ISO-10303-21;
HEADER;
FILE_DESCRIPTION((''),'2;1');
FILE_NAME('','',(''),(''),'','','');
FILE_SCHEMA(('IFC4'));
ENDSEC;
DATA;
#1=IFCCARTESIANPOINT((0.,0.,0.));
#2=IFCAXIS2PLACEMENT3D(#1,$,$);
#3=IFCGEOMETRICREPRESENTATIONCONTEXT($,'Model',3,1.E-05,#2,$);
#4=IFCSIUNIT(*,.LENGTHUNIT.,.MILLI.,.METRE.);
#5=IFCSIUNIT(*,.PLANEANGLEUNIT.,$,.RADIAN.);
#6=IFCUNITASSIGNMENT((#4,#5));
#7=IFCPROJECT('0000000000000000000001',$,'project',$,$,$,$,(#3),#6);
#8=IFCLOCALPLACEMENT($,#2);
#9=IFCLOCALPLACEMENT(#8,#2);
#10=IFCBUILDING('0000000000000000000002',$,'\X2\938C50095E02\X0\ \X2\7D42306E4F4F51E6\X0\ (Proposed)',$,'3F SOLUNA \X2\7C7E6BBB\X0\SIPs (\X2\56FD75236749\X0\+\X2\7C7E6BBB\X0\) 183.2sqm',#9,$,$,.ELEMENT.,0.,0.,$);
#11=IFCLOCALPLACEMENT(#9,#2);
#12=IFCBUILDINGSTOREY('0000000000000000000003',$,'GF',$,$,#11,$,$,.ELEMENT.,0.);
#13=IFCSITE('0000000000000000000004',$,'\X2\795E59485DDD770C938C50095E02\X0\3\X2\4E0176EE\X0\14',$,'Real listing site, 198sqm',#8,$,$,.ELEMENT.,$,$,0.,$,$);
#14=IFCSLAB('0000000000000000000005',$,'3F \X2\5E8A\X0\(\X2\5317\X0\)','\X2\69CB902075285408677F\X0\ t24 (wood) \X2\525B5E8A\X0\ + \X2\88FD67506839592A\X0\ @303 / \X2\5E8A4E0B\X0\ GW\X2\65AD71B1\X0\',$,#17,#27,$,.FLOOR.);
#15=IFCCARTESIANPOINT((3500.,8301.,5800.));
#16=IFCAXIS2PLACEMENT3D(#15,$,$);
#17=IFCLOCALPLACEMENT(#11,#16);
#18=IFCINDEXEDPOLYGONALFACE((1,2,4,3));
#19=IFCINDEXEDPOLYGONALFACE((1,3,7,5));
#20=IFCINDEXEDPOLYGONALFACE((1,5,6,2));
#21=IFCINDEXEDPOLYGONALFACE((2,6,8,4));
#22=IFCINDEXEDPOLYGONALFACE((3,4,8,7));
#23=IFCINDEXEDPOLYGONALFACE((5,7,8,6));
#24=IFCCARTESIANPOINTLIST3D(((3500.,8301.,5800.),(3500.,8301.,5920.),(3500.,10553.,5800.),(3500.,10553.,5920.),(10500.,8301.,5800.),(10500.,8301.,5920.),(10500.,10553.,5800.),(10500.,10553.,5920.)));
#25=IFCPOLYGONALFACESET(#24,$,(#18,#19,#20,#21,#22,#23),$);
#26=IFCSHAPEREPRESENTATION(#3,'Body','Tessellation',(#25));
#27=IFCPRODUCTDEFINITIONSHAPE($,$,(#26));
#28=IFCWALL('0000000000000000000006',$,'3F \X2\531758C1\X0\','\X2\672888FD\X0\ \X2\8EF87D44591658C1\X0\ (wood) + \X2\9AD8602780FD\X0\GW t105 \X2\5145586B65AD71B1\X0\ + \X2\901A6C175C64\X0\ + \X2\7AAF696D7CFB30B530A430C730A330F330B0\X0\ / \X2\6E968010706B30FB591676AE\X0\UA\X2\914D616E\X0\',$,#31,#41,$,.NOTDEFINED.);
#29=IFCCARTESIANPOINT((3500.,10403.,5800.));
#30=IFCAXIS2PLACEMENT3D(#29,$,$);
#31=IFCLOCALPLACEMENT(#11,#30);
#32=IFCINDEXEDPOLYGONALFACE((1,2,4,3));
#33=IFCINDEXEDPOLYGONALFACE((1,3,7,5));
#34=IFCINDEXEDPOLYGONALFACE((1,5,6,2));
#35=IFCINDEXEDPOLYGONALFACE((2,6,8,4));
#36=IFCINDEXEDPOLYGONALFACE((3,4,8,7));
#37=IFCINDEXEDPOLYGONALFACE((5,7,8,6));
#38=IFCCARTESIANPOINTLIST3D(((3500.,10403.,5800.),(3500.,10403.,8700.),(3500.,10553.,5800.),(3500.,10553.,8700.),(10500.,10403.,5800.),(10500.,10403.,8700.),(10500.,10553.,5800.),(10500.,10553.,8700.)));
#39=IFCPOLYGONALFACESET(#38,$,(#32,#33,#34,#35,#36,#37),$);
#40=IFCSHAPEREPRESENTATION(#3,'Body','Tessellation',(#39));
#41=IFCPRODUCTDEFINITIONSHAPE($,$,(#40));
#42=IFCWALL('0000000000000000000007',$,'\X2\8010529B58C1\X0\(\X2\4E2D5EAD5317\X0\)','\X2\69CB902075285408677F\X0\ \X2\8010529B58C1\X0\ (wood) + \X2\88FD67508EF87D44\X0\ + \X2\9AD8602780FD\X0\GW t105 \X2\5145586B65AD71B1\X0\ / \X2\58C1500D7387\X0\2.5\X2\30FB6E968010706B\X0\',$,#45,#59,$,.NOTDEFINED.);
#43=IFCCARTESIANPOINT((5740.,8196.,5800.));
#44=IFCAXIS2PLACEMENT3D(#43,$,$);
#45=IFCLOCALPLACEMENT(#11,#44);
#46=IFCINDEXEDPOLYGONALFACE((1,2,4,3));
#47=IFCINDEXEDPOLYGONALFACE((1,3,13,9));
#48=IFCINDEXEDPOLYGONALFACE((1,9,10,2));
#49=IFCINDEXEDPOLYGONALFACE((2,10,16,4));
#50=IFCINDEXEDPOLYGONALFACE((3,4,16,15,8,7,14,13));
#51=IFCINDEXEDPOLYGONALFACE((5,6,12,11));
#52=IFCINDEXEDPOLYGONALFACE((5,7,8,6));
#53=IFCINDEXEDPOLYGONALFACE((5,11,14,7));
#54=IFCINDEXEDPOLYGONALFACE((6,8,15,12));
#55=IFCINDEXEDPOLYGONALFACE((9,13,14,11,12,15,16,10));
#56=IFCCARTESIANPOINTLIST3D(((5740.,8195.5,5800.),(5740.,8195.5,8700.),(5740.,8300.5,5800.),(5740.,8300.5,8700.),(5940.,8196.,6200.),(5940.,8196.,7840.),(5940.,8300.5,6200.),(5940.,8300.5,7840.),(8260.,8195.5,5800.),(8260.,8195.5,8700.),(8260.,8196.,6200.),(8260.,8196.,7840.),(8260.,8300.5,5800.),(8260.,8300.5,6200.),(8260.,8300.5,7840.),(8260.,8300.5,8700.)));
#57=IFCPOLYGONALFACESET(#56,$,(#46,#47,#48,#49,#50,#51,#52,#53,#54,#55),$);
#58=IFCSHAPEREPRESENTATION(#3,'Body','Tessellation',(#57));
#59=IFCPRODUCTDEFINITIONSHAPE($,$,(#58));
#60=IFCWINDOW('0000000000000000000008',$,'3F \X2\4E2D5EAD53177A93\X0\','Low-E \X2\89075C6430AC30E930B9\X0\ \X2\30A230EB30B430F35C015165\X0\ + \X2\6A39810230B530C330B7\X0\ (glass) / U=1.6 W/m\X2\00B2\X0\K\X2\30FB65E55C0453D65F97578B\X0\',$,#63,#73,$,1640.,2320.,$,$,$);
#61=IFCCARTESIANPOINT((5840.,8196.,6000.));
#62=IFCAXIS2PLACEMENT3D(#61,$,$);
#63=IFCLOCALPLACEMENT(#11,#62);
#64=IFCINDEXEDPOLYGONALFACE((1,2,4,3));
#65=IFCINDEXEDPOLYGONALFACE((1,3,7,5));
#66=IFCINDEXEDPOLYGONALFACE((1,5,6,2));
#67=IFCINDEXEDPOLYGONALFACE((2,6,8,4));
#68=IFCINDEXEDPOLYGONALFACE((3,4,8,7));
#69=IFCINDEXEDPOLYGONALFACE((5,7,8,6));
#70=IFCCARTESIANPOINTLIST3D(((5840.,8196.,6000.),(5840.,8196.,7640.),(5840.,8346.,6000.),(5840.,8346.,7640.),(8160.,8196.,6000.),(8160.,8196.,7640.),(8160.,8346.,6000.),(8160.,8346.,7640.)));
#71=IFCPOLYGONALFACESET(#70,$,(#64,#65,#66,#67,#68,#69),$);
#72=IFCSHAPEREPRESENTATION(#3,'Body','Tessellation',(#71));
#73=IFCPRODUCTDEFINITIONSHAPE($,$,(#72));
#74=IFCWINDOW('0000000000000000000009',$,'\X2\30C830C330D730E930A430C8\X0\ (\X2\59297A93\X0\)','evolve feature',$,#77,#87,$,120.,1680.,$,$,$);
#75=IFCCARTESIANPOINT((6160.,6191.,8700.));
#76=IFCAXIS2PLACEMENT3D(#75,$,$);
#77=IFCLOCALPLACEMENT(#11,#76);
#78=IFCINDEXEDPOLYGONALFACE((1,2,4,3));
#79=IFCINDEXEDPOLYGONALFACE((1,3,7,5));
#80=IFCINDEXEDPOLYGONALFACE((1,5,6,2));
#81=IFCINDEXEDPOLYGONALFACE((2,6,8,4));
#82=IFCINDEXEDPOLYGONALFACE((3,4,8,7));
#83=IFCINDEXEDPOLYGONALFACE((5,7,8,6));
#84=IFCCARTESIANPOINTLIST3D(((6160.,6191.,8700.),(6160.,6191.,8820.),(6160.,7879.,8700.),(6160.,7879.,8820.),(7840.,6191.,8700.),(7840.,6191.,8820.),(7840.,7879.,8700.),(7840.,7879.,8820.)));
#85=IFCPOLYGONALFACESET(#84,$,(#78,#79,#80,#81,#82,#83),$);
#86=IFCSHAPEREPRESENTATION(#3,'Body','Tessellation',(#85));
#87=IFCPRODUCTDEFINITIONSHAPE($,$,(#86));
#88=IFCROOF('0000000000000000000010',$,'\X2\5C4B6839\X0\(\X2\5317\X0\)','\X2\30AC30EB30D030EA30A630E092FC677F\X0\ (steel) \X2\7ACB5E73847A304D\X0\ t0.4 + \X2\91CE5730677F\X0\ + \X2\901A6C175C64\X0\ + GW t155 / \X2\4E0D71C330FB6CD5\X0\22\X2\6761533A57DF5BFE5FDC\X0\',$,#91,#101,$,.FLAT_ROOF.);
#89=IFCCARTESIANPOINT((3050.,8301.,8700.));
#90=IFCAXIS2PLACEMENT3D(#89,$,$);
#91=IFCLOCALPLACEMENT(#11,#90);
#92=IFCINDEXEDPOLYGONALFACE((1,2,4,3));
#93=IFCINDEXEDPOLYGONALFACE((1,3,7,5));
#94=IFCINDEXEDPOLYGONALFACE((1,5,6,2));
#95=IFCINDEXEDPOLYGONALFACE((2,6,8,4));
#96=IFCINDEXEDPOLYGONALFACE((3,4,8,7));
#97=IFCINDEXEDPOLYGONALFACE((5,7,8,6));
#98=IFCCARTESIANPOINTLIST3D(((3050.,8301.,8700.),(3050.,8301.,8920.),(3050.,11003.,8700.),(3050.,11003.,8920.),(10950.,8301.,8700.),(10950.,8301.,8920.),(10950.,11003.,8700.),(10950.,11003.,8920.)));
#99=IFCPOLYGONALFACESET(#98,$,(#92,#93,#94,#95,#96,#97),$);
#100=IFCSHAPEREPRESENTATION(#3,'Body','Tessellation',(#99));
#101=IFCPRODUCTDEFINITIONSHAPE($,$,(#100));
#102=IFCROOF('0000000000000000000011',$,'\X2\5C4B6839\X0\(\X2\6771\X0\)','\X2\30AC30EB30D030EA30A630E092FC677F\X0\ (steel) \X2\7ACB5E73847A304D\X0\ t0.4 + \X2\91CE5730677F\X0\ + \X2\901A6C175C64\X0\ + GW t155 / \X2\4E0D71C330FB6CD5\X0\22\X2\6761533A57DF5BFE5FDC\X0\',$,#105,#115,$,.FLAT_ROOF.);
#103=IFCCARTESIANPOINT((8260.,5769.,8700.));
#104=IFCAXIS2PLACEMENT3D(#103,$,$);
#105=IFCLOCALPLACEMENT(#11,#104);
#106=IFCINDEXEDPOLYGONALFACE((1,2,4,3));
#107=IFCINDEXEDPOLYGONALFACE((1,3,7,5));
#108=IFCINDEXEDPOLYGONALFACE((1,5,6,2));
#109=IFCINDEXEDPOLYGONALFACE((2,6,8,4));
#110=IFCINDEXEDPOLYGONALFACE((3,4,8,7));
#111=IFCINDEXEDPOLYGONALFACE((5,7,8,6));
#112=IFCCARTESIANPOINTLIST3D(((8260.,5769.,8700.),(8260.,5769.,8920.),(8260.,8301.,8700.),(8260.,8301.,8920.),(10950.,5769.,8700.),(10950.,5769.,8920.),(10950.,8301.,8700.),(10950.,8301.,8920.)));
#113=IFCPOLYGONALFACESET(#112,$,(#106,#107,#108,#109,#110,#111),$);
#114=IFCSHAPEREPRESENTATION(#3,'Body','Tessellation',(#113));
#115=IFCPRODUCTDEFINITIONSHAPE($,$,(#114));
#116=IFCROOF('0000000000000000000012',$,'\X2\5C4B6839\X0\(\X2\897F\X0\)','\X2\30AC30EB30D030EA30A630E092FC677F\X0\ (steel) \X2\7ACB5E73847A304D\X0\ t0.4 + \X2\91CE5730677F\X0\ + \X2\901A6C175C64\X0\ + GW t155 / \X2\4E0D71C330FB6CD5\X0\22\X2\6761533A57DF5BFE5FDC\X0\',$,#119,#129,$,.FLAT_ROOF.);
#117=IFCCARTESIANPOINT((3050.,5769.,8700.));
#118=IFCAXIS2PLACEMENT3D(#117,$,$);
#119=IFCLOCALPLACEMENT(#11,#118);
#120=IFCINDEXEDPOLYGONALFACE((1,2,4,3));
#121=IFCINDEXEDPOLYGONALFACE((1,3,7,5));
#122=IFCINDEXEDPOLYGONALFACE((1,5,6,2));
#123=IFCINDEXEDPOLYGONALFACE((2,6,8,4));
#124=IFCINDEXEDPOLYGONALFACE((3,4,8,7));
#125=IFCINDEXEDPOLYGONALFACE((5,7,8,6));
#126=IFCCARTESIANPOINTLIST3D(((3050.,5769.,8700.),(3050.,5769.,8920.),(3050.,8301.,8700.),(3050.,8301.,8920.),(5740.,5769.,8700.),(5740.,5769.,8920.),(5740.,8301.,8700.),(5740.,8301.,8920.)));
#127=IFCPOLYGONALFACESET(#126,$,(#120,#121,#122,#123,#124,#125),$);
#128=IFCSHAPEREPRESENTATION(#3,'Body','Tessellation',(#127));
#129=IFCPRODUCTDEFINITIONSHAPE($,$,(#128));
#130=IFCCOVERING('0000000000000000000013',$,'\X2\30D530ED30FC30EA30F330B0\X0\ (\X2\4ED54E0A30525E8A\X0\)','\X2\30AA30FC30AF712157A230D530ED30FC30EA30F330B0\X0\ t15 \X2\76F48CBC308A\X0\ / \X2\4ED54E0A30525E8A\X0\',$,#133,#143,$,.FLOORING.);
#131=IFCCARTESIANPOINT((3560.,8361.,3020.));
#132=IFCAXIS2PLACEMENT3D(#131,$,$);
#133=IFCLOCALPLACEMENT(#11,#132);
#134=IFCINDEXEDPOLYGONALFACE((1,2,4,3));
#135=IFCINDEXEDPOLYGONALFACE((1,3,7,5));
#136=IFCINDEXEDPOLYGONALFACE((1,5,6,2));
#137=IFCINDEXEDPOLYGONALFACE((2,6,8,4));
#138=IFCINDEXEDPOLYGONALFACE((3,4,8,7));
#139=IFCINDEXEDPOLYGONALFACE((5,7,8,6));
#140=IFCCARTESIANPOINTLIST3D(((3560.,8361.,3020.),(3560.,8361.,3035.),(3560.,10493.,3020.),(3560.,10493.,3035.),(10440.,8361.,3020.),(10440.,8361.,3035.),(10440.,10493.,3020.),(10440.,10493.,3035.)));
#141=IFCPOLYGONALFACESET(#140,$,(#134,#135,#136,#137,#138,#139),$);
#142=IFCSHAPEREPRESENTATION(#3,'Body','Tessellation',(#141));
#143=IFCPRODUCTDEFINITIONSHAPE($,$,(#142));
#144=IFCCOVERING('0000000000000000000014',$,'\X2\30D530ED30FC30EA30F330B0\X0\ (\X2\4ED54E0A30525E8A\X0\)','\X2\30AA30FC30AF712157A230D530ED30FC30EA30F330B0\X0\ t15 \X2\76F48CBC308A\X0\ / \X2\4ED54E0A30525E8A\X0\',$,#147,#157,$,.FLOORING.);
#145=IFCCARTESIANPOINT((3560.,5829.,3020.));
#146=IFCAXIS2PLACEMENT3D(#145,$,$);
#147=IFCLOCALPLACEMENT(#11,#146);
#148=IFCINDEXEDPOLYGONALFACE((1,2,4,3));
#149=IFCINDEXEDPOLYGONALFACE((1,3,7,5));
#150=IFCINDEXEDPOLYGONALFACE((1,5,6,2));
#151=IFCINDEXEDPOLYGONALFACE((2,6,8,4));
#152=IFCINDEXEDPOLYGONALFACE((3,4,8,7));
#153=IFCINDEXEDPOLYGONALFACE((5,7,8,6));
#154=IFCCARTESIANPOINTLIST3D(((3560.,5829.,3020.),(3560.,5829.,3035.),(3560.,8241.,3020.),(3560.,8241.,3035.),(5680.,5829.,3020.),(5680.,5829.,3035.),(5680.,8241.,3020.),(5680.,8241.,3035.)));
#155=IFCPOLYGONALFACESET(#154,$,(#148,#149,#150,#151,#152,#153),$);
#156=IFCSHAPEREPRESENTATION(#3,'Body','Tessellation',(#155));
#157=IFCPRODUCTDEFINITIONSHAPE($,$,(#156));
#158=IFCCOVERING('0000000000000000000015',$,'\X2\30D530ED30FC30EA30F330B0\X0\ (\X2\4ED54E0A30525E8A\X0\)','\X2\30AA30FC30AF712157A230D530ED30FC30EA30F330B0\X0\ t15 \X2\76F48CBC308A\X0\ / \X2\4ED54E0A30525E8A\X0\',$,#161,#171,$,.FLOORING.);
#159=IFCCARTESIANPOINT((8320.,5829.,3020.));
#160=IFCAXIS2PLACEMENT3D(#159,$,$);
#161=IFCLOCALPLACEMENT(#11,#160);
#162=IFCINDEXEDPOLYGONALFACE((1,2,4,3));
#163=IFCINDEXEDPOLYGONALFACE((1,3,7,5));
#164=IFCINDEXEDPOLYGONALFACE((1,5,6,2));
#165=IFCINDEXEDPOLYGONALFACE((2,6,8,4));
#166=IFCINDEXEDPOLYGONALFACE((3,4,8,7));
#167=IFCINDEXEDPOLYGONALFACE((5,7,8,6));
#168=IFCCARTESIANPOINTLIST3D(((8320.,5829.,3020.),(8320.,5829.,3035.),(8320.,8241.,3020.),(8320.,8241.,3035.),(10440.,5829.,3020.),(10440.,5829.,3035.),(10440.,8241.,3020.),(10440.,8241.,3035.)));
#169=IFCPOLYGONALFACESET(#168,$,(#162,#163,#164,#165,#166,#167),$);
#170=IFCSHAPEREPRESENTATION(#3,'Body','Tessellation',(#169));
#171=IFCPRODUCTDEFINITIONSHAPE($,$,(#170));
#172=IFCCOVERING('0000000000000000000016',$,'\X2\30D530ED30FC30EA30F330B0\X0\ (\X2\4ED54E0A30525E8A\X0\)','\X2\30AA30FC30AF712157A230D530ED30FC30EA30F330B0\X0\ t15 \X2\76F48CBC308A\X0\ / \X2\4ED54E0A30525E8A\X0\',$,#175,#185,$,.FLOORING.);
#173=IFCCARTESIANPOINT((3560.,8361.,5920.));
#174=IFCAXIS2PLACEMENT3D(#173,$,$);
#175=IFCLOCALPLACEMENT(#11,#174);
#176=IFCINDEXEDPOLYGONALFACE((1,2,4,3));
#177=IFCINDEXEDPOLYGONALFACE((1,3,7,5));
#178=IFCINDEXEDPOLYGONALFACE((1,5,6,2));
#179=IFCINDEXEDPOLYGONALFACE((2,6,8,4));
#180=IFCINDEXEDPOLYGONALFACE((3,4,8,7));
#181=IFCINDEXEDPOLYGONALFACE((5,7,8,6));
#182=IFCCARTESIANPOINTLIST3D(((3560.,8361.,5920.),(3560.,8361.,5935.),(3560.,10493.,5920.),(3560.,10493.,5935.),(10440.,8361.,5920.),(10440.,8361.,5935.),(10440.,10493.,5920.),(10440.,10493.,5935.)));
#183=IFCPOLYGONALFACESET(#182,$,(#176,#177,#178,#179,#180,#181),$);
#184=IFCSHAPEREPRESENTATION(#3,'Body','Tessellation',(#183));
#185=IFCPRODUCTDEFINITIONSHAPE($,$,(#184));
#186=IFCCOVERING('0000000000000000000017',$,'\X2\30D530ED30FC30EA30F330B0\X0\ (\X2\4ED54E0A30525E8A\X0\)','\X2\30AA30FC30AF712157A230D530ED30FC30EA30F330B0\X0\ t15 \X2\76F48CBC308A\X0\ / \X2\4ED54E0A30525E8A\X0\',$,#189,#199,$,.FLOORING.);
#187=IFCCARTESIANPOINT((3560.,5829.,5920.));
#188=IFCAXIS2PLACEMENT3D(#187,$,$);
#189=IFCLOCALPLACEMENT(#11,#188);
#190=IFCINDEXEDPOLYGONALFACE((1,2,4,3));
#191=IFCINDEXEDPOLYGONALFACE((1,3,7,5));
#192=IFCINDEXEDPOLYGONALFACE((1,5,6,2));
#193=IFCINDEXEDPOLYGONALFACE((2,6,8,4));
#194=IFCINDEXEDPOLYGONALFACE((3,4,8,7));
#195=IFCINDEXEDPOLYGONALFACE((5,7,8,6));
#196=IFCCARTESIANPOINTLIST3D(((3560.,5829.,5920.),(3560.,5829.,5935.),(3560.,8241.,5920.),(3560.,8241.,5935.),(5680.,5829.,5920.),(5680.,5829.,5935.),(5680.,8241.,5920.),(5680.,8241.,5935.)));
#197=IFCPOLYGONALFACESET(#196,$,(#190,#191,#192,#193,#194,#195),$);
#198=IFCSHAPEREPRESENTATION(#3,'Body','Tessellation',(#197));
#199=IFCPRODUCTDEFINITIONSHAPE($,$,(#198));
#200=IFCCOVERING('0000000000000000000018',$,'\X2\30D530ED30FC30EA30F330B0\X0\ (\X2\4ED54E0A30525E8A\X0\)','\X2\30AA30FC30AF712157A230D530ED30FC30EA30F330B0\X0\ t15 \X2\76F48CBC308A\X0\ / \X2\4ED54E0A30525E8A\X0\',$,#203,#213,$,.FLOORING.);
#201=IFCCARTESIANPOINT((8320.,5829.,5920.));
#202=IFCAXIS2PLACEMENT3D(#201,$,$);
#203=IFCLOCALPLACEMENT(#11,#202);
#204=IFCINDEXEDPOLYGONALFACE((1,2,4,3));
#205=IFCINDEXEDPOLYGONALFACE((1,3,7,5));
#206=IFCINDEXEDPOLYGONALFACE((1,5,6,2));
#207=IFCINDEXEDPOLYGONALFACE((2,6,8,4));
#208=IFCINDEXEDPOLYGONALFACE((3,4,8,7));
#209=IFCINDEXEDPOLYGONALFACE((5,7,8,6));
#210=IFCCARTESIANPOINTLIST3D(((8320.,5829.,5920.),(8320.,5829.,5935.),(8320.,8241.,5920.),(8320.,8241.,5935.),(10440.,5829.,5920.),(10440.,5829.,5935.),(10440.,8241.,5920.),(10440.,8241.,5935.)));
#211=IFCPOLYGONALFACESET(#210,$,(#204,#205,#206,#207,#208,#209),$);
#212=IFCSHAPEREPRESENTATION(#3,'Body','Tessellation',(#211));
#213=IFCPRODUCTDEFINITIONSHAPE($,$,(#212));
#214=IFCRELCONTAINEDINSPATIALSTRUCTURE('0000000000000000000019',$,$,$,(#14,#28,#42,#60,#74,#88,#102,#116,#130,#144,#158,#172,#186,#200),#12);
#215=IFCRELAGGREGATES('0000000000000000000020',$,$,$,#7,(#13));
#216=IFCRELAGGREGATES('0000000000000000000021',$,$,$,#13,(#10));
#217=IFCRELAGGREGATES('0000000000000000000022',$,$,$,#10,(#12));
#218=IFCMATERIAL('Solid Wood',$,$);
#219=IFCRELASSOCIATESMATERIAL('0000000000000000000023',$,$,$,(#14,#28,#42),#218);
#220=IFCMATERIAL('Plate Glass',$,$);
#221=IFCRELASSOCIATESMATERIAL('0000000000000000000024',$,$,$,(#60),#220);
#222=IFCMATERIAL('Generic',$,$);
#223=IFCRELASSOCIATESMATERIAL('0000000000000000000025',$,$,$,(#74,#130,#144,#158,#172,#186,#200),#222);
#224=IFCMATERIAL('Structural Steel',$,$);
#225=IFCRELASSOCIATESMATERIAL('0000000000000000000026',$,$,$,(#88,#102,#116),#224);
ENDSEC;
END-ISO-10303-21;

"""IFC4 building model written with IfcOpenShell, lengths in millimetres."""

from ifc_helpers import new_model, si_unit, frame, frame_2d, origin, place, context, project, spatial, rectangle, extrude, material, element, fill, save


model = new_model("IFC4")

# Units and contexts
model_context = context("Model", 3, precision=1e-05, world=origin())
ifc_project = project(units=[si_unit("LENGTHUNIT", "METRE", prefix="MILLI"), si_unit("PLANEANGLEUNIT", "RADIAN")], contexts=[model_context])

# Site, building, storey
site_placement = place(None, origin())
site = spatial("IfcSite", under=ifc_project, at=site_placement, Name="神奈川県鎌倉市3丁目14", ObjectType="Real listing site, 198sqm", CompositionType="ELEMENT", RefElevation=0.0)
building_placement = place(site_placement, origin())
building = spatial("IfcBuilding", under=site, at=building_placement, Name="鎌倉市 終の住処 (Proposed)", ObjectType="3F SOLUNA 籾殻SIPs (国産杉+籾殻) 183.2sqm", CompositionType="ELEMENT", ElevationOfRefHeight=0.0, ElevationOfTerrain=0.0)
storey_placement = place(building_placement, origin())
storey = spatial("IfcBuildingStorey", under=building, at=storey_placement, Name="GF", CompositionType="ELEMENT", Elevation=0.0)

# Slab
ifc_material_1 = material(Name="Solid Wood")
slab_placement = place(storey_placement, frame((3500.0, 8301.0, 5800.0)))
element("IfcSlab", 1, at=slab_placement, inside=storey, material=ifc_material_1, Name="3F 床(北)", Description="構造用合板 t24 (wood) 剛床 + 製材根太 @303 / 床下 GW断熱", PredefinedType="FLOOR", context=model_context, shape_type="SweptSolid", body=[
    extrude(rectangle(XDim=7000.0, YDim=2252.0, at=frame_2d((3500.0, 1126.0))), frame((3500.0, 8301.0, 5800.0)), (0.0, 0.0, 1.0), 120.0),
])

# Wall
wall_1_placement = place(storey_placement, frame((3500.0, 10403.0, 5800.0)))
element("IfcWall", 2, at=wall_1_placement, inside=storey, material=ifc_material_1, Name="3F 北壁", Description="木製 軸組外壁 (wood) + 高性能GW t105 充填断熱 + 通気層 + 窯業系サイディング / 準耐火・外皮UA配慮", PredefinedType="NOTDEFINED", context=model_context, shape_type="SweptSolid", body=[
    extrude(rectangle(XDim=7000.0, YDim=150.0, at=frame_2d((3500.0, 75.0))), frame((3500.0, 10403.0, 5800.0)), (0.0, 0.0, 1.0), 2900.0),
])

# Wall, opening, window
wall_2_placement = place(storey_placement, frame((5740.0, 8196.0, 5800.0)))
wall_2 = element("IfcWall", 3, at=wall_2_placement, inside=storey, material=ifc_material_1, Name="耐力壁(中庭北)", Description="構造用合板 耐力壁 (wood) + 製材軸組 + 高性能GW t105 充填断熱 / 壁倍率2.5・準耐火", PredefinedType="NOTDEFINED", context=model_context, shape_type="SweptSolid", body=[
    extrude(rectangle(XDim=2520.0, YDim=105.0, at=frame_2d((1260.0, 52.0))), frame((5740.0, 8196.0, 5800.0)), (0.0, 0.0, 1.0), 2900.0),
])
opening_placement = place(storey_placement, frame((5840.0, 8196.0, 6000.0)))
opening = element("IfcOpeningElement", 4, at=opening_placement, cuts=wall_2, PredefinedType="NOTDEFINED", context=model_context, shape_type="SweptSolid", body=[
    extrude(rectangle(XDim=2320.0, YDim=150.0, at=frame_2d((1160.0, 75.0))), frame((5840.0, 8196.0, 6000.0)), (0.0, 0.0, 1.0), 1640.0),
])
ifc_material_2 = material(Name="Plate Glass")
window_1_placement = place(storey_placement, frame((5840.0, 8196.0, 6000.0)))
window_1 = element("IfcWindow", 5, at=window_1_placement, inside=storey, material=ifc_material_2, Name="3F 中庭北窓", Description="Low-E 複層ガラス アルゴン封入 + 樹脂サッシ (glass) / U=1.6 W/m²K・日射取得型", OverallHeight=1640.0, OverallWidth=2320.0, context=model_context, shape_type="SweptSolid", body=[
    extrude(rectangle(XDim=2320.0, YDim=150.0, at=frame_2d((1160.0, 75.0))), frame((5840.0, 8196.0, 6000.0)), (0.0, 0.0, 1.0), 1640.0),
])
fill(opening, window_1)

# Window
ifc_material_3 = material(Name="Generic")
window_2_placement = place(storey_placement, frame((6160.0, 6191.0, 8700.0)))
element("IfcWindow", 6, at=window_2_placement, inside=storey, material=ifc_material_3, Name="トップライト (天窓)", Description="evolve feature", OverallHeight=120.0, OverallWidth=1680.0, context=model_context, shape_type="SweptSolid", body=[
    extrude(rectangle(XDim=1680.0, YDim=1688.0, at=frame_2d((840.0, 844.0))), frame((6160.0, 6191.0, 8700.0)), (0.0, 0.0, 1.0), 120.0),
])

# Roofs
ifc_material_4 = material(Name="Structural Steel")
roof_1_placement = place(storey_placement, frame((3050.0, 8301.0, 8700.0)))
element("IfcRoof", 7, at=roof_1_placement, inside=storey, material=ifc_material_4, Name="屋根(北)", Description="ガルバリウム鋼板 (steel) 立平葺き t0.4 + 野地板 + 通気層 + GW t155 / 不燃・法22条区域対応", PredefinedType="FLAT_ROOF", context=model_context, shape_type="SweptSolid", body=[
    extrude(rectangle(XDim=7900.0, YDim=2702.0, at=frame_2d((3950.0, 1351.0))), frame((3050.0, 8301.0, 8700.0)), (0.0, 0.0, 1.0), 220.0),
])
roof_2_placement = place(storey_placement, frame((8260.0, 5769.0, 8700.0)))
element("IfcRoof", 8, at=roof_2_placement, inside=storey, material=ifc_material_4, Name="屋根(東)", Description="ガルバリウム鋼板 (steel) 立平葺き t0.4 + 野地板 + 通気層 + GW t155 / 不燃・法22条区域対応", PredefinedType="FLAT_ROOF", context=model_context, shape_type="SweptSolid", body=[
    extrude(rectangle(XDim=2690.0, YDim=2532.0, at=frame_2d((1345.0, 1266.0))), frame((8260.0, 5769.0, 8700.0)), (0.0, 0.0, 1.0), 220.0),
])
roof_3_placement = place(storey_placement, frame((3050.0, 5769.0, 8700.0)))
element("IfcRoof", 9, at=roof_3_placement, inside=storey, material=ifc_material_4, Name="屋根(西)", Description="ガルバリウム鋼板 (steel) 立平葺き t0.4 + 野地板 + 通気層 + GW t155 / 不燃・法22条区域対応", PredefinedType="FLAT_ROOF", context=model_context, shape_type="SweptSolid", body=[
    extrude(rectangle(XDim=2690.0, YDim=2532.0, at=frame_2d((1345.0, 1266.0))), frame((3050.0, 5769.0, 8700.0)), (0.0, 0.0, 1.0), 220.0),
])

# Coverings
covering_1_placement = place(storey_placement, frame((3560.0, 8361.0, 3020.0)))
element("IfcCovering", 10, at=covering_1_placement, inside=storey, material=ifc_material_3, Name="フローリング (仕上げ床)", Description="オーク無垢フローリング t15 直貼り / 仕上げ床", PredefinedType="FLOORING", context=model_context, shape_type="SweptSolid", body=[
    extrude(rectangle(XDim=6880.0, YDim=2132.0, at=frame_2d((3440.0, 1066.0))), frame((3560.0, 8361.0, 3020.0)), (0.0, 0.0, 1.0), 15.0),
])
covering_2_placement = place(storey_placement, frame((3560.0, 5829.0, 3020.0)))
element("IfcCovering", 11, at=covering_2_placement, inside=storey, material=ifc_material_3, Name="フローリング (仕上げ床)", Description="オーク無垢フローリング t15 直貼り / 仕上げ床", PredefinedType="FLOORING", context=model_context, shape_type="SweptSolid", body=[
    extrude(rectangle(XDim=2120.0, YDim=2412.0, at=frame_2d((1060.0, 1206.0))), frame((3560.0, 5829.0, 3020.0)), (0.0, 0.0, 1.0), 15.0),
])
covering_3_placement = place(storey_placement, frame((8320.0, 5829.0, 3020.0)))
element("IfcCovering", 12, at=covering_3_placement, inside=storey, material=ifc_material_3, Name="フローリング (仕上げ床)", Description="オーク無垢フローリング t15 直貼り / 仕上げ床", PredefinedType="FLOORING", context=model_context, shape_type="SweptSolid", body=[
    extrude(rectangle(XDim=2120.0, YDim=2412.0, at=frame_2d((1060.0, 1206.0))), frame((8320.0, 5829.0, 3020.0)), (0.0, 0.0, 1.0), 15.0),
])
covering_4_placement = place(storey_placement, frame((3560.0, 8361.0, 5920.0)))
element("IfcCovering", 13, at=covering_4_placement, inside=storey, material=ifc_material_3, Name="フローリング (仕上げ床)", Description="オーク無垢フローリング t15 直貼り / 仕上げ床", PredefinedType="FLOORING", context=model_context, shape_type="SweptSolid", body=[
    extrude(rectangle(XDim=6880.0, YDim=2132.0, at=frame_2d((3440.0, 1066.0))), frame((3560.0, 8361.0, 5920.0)), (0.0, 0.0, 1.0), 15.0),
])
covering_5_placement = place(storey_placement, frame((3560.0, 5829.0, 5920.0)))
element("IfcCovering", 14, at=covering_5_placement, inside=storey, material=ifc_material_3, Name="フローリング (仕上げ床)", Description="オーク無垢フローリング t15 直貼り / 仕上げ床", PredefinedType="FLOORING", context=model_context, shape_type="SweptSolid", body=[
    extrude(rectangle(XDim=2120.0, YDim=2412.0, at=frame_2d((1060.0, 1206.0))), frame((3560.0, 5829.0, 5920.0)), (0.0, 0.0, 1.0), 15.0),
])
covering_6_placement = place(storey_placement, frame((8320.0, 5829.0, 5920.0)))
element("IfcCovering", 15, at=covering_6_placement, inside=storey, material=ifc_material_3, Name="フローリング (仕上げ床)", Description="オーク無垢フローリング t15 直貼り / 仕上げ床", PredefinedType="FLOORING", context=model_context, shape_type="SweptSolid", body=[
    extrude(rectangle(XDim=2120.0, YDim=2412.0, at=frame_2d((1060.0, 1206.0))), frame((8320.0, 5829.0, 5920.0)), (0.0, 0.0, 1.0), 15.0),
])

save(model, "model.ifc")
